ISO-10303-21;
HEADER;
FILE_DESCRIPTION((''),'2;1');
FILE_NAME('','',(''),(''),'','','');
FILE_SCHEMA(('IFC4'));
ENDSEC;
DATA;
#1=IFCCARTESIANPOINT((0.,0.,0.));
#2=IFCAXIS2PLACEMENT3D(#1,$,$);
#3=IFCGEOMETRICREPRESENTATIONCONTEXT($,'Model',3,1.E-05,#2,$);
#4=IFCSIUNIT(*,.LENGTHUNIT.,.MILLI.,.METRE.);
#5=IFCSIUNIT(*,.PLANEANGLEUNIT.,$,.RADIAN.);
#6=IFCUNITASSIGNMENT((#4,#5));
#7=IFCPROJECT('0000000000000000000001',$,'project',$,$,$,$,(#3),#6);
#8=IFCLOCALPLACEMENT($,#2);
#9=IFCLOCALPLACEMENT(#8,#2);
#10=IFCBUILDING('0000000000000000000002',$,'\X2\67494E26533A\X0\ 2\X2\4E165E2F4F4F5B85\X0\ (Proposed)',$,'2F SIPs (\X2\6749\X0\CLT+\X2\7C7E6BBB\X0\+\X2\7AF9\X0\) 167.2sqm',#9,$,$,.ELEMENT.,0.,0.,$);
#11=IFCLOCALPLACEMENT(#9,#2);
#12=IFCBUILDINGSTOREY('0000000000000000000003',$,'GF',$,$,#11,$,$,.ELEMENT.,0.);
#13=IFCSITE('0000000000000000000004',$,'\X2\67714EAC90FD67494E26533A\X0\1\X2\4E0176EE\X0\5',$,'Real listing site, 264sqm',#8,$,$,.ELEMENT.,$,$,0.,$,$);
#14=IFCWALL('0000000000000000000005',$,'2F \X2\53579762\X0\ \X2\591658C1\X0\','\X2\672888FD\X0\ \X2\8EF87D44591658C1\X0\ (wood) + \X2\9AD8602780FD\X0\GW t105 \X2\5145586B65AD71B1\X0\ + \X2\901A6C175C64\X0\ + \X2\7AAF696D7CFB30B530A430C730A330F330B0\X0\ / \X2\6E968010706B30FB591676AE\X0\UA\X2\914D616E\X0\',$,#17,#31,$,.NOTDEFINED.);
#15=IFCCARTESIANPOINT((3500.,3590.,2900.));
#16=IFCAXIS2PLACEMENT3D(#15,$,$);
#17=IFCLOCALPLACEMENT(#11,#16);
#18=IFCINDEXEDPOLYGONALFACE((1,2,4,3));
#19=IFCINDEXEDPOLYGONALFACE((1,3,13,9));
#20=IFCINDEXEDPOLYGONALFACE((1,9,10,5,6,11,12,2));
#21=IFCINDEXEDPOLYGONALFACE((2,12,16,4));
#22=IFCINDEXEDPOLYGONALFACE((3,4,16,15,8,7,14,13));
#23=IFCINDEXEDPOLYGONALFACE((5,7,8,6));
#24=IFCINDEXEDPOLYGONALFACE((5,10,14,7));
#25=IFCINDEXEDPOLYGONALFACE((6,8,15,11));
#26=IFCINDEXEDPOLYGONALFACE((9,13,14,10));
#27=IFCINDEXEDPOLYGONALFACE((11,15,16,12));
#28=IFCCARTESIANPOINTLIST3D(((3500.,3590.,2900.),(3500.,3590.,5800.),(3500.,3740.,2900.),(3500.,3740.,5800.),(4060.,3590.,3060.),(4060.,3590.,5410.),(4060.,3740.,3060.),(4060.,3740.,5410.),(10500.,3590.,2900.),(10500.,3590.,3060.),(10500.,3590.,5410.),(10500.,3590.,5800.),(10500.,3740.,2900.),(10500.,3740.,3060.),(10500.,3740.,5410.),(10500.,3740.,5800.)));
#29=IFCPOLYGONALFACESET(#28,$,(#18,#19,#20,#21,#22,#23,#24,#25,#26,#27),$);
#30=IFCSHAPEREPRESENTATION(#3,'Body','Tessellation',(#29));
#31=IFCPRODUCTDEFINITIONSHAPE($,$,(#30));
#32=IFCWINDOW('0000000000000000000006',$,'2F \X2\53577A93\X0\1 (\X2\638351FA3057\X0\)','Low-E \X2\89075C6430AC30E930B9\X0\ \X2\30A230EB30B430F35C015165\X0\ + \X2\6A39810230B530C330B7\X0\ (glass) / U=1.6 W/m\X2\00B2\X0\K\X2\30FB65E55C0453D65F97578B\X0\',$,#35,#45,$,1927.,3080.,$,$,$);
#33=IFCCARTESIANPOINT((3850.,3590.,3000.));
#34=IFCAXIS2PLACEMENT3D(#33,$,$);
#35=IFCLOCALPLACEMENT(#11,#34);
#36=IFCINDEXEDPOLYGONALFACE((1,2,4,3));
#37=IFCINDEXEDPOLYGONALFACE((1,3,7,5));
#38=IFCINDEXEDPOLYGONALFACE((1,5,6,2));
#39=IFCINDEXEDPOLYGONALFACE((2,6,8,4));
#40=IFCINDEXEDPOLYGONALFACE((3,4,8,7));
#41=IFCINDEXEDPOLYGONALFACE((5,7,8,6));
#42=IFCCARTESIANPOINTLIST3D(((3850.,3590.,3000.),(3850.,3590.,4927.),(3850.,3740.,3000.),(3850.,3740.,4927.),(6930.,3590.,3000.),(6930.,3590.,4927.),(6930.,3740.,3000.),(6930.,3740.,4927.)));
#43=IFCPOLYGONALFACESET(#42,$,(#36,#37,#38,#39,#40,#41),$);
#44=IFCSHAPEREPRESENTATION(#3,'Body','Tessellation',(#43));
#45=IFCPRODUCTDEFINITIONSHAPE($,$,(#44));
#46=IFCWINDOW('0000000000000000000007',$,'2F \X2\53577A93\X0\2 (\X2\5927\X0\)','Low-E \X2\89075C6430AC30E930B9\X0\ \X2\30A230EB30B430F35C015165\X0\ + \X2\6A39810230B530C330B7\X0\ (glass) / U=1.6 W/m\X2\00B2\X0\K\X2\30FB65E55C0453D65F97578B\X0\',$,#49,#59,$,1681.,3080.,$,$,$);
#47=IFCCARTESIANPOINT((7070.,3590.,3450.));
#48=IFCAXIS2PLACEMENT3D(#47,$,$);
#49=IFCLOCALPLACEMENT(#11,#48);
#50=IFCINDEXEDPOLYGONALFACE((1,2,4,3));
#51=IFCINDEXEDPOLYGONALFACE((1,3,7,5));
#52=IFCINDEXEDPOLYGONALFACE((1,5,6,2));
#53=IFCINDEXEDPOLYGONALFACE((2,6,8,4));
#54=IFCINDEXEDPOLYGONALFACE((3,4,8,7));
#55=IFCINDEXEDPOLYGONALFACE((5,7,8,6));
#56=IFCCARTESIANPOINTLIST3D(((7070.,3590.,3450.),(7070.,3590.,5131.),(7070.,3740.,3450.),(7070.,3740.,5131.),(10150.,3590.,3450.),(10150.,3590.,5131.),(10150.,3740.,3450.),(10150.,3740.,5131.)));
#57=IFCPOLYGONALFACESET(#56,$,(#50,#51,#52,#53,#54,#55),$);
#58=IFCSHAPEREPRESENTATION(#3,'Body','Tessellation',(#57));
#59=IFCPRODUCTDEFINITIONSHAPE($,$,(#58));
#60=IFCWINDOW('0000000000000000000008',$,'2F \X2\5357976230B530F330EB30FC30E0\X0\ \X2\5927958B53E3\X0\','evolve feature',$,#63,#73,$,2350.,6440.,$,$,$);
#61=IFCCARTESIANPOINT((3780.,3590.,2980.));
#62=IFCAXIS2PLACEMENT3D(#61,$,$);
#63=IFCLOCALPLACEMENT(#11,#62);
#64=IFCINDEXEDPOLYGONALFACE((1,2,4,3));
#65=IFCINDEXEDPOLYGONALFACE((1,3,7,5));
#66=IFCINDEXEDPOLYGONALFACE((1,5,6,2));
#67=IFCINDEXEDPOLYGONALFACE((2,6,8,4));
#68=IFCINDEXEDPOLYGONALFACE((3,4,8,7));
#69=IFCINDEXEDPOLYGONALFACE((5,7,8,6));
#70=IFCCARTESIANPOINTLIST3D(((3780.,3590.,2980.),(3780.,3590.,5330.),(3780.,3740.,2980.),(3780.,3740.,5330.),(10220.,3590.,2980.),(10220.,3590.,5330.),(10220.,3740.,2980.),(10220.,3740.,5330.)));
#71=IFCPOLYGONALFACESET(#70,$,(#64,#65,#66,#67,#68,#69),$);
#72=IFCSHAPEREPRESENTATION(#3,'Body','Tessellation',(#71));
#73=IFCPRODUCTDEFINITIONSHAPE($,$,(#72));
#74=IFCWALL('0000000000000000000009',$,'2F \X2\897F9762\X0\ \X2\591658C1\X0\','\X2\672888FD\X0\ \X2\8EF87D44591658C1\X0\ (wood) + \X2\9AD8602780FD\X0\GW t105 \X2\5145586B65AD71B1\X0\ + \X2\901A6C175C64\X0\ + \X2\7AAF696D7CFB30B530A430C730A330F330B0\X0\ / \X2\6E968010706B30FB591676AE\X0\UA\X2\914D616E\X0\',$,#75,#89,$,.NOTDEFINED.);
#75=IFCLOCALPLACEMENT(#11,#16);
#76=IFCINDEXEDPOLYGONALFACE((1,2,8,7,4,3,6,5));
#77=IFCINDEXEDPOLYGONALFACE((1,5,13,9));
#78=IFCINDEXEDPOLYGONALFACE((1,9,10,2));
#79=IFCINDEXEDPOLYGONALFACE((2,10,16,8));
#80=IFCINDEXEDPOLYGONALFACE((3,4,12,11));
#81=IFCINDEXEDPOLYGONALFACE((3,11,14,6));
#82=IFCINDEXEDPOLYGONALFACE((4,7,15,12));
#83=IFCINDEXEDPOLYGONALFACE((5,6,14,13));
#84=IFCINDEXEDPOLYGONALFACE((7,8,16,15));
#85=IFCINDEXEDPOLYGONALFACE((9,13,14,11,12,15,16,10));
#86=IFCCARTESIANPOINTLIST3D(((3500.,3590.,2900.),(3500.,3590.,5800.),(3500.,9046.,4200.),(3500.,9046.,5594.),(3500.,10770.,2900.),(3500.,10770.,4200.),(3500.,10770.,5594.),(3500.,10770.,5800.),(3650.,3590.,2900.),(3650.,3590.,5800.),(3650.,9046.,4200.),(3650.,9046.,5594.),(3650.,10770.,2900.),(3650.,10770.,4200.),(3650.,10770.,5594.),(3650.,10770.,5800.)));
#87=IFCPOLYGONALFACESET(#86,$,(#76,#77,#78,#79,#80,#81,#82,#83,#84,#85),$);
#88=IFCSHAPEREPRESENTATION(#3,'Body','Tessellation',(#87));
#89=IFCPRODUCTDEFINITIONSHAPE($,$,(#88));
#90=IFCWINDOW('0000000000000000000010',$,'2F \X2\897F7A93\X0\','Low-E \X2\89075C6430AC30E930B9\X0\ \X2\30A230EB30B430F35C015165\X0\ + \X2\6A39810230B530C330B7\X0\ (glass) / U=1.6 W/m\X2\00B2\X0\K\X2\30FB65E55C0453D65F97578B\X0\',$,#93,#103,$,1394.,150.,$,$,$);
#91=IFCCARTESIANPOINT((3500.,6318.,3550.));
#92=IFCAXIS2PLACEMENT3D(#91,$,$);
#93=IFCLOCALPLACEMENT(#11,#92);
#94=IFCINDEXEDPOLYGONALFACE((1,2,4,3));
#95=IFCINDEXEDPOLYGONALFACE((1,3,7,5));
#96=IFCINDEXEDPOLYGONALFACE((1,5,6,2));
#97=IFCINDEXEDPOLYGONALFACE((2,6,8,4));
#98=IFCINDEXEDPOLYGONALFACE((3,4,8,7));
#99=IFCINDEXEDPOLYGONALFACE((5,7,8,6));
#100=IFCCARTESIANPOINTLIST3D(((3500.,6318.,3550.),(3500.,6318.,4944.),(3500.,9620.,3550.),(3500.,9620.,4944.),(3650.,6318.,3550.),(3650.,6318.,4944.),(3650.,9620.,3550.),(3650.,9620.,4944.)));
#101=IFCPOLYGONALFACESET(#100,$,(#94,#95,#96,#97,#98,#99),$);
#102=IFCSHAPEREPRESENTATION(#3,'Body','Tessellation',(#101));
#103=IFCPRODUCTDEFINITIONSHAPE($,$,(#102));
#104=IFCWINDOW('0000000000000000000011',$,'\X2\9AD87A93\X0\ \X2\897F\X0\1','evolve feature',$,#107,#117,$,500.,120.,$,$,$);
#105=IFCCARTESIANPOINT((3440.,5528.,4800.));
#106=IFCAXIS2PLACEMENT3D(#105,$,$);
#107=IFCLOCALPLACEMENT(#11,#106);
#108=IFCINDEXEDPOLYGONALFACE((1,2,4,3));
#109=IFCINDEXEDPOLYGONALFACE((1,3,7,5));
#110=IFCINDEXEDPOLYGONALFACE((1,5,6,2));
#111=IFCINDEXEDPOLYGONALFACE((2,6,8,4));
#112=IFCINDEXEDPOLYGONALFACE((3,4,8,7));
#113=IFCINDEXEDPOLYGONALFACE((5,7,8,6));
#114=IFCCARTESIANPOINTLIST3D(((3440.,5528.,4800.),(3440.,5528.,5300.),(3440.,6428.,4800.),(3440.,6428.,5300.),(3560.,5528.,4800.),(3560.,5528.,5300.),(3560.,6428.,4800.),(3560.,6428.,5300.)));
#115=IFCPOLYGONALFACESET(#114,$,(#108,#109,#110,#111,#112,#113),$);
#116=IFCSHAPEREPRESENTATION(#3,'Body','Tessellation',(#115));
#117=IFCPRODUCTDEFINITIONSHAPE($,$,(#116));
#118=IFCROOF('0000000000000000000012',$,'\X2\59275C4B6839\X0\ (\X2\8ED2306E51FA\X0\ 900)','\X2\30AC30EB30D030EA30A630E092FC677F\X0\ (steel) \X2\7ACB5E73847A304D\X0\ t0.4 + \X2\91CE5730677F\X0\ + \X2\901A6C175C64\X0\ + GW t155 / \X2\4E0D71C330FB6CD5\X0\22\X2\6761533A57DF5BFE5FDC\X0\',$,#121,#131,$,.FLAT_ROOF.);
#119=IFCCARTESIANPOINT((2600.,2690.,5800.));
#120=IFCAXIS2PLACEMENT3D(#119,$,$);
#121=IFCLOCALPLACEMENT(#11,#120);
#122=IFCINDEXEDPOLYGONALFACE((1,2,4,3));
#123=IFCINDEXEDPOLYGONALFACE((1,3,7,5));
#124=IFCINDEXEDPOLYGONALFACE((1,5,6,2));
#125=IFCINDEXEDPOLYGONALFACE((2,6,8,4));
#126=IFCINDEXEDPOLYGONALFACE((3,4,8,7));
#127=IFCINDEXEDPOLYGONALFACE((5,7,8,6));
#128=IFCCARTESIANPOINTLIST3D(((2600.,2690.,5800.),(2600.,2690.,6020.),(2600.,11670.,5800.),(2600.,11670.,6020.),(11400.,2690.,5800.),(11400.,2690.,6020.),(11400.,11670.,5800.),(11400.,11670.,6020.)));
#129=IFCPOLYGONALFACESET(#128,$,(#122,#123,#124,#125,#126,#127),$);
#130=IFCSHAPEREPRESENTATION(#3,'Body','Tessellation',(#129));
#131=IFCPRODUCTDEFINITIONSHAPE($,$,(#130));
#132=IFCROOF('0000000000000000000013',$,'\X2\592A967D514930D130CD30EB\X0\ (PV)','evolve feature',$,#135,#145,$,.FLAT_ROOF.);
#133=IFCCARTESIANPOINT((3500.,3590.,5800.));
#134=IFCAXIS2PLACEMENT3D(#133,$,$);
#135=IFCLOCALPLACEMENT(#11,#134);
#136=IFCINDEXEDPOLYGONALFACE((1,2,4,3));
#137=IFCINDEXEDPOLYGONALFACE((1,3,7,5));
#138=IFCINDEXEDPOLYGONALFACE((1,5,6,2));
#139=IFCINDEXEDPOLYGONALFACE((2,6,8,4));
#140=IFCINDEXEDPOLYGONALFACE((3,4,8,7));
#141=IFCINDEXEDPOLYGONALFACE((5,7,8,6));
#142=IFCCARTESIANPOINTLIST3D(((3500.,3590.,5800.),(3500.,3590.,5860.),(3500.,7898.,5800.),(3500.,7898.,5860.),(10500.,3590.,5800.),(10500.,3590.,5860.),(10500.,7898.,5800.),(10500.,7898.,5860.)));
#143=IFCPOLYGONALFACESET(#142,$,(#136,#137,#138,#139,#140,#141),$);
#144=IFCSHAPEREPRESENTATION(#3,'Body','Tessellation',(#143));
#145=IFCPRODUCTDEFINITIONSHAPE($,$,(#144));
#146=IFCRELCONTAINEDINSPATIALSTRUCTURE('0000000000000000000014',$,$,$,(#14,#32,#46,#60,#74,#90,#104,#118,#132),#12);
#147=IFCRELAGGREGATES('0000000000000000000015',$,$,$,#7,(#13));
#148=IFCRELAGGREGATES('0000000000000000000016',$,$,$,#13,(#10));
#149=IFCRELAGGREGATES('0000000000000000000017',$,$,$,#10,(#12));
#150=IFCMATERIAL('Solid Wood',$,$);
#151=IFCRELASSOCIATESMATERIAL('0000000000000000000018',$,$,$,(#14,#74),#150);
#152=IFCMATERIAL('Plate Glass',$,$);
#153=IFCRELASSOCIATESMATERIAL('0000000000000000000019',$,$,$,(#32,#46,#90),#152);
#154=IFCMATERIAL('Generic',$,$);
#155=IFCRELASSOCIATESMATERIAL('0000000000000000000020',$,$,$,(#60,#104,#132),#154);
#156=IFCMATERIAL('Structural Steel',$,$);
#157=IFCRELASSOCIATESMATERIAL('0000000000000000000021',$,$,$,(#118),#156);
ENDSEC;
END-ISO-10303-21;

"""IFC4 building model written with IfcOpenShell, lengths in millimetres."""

from ifc_helpers import new_model, si_unit, frame, frame_2d, origin, place, context, project, spatial, rectangle, extrude, material, element, fill, save


model = new_model("IFC4")

# Units and contexts
model_context = context("Model", 3, precision=1e-05, world=origin())
ifc_project = project(units=[si_unit("LENGTHUNIT", "METRE", prefix="MILLI"), si_unit("PLANEANGLEUNIT", "RADIAN")], contexts=[model_context])

# Site, building, storey
site_placement = place(None, origin())
site = spatial("IfcSite", under=ifc_project, at=site_placement, Name="東京都杉並区1丁目5", ObjectType="Real listing site, 264sqm", CompositionType="ELEMENT", RefElevation=0.0)
building_placement = place(site_placement, origin())
building = spatial("IfcBuilding", under=site, at=building_placement, Name="杉並区 2世帯住宅 (Proposed)", ObjectType="2F SIPs (杉CLT+籾殻+竹) 167.2sqm", CompositionType="ELEMENT", ElevationOfRefHeight=0.0, ElevationOfTerrain=0.0)
storey_placement = place(building_placement, origin())
storey = spatial("IfcBuildingStorey", under=building, at=storey_placement, Name="GF", CompositionType="ELEMENT", Elevation=0.0)

# Shared definitions
ifc_material_1 = material(Name="Solid Wood")
ifc_material_2 = material(Name="Generic")

# Shared definitions
ifc_material_3 = material(Name="Plate Glass")

# Walls, openings, windows
wall_1_placement = place(storey_placement, frame((3500.0, 3590.0, 2900.0)))
wall_1 = element("IfcWall", 1, at=wall_1_placement, inside=storey, material=ifc_material_1, Name="2F 南面 外壁", Description="木製 軸組外壁 (wood) + 高性能GW t105 充填断熱 + 通気層 + 窯業系サイディング / 準耐火・外皮UA配慮", PredefinedType="NOTDEFINED", context=model_context, shape_type="SweptSolid", body=[
    extrude(rectangle(XDim=7000.0, YDim=150.0, at=frame_2d((3500.0, 75.0))), frame((3500.0, 3590.0, 2900.0)), (0.0, 0.0, 1.0), 2900.0),
])
opening_1_placement = place(storey_placement, frame((3850.0, 3590.0, 3000.0)))
opening_1 = element("IfcOpeningElement", 2, at=opening_1_placement, cuts=wall_1, PredefinedType="NOTDEFINED", context=model_context, shape_type="SweptSolid", body=[
    extrude(rectangle(XDim=3080.0, YDim=150.0, at=frame_2d((1540.0, 75.0))), frame((3850.0, 3590.0, 3000.0)), (0.0, 0.0, 1.0), 1927.0),
])
opening_2_placement = place(storey_placement, frame((7070.0, 3590.0, 3450.0)))
opening_2 = element("IfcOpeningElement", 3, at=opening_2_placement, cuts=wall_1, PredefinedType="NOTDEFINED", context=model_context, shape_type="SweptSolid", body=[
    extrude(rectangle(XDim=3080.0, YDim=150.0, at=frame_2d((1540.0, 75.0))), frame((7070.0, 3590.0, 3450.0)), (0.0, 0.0, 1.0), 1681.0),
])
opening_3_placement = place(storey_placement, frame((3780.0, 3590.0, 2980.0)))
opening_3 = element("IfcOpeningElement", 4, at=opening_3_placement, cuts=wall_1, PredefinedType="NOTDEFINED", context=model_context, shape_type="SweptSolid", body=[
    extrude(rectangle(XDim=6440.0, YDim=150.0, at=frame_2d((3220.0, 75.0))), frame((3780.0, 3590.0, 2980.0)), (0.0, 0.0, 1.0), 2350.0),
])
window_1_placement = place(storey_placement, frame((3850.0, 3590.0, 3000.0)))
window_1 = element("IfcWindow", 5, at=window_1_placement, inside=storey, material=ifc_material_3, Name="2F 南窓1 (掃出し)", Description="Low-E 複層ガラス アルゴン封入 + 樹脂サッシ (glass) / U=1.6 W/m²K・日射取得型", OverallHeight=1927.0, OverallWidth=3080.0, context=model_context, shape_type="SweptSolid", body=[
    extrude(rectangle(XDim=3080.0, YDim=150.0, at=frame_2d((1540.0, 75.0))), frame((3850.0, 3590.0, 3000.0)), (0.0, 0.0, 1.0), 1927.0),
])
fill(opening_1, window_1)
window_2_placement = place(storey_placement, frame((7070.0, 3590.0, 3450.0)))
window_2 = element("IfcWindow", 6, at=window_2_placement, inside=storey, material=ifc_material_3, Name="2F 南窓2 (大)", Description="Low-E 複層ガラス アルゴン封入 + 樹脂サッシ (glass) / U=1.6 W/m²K・日射取得型", OverallHeight=1681.0, OverallWidth=3080.0, context=model_context, shape_type="SweptSolid", body=[
    extrude(rectangle(XDim=3080.0, YDim=150.0, at=frame_2d((1540.0, 75.0))), frame((7070.0, 3590.0, 3450.0)), (0.0, 0.0, 1.0), 1681.0),
])
fill(opening_2, window_2)
window_3_placement = place(storey_placement, frame((3780.0, 3590.0, 2980.0)))
window_3 = element("IfcWindow", 7, at=window_3_placement, inside=storey, material=ifc_material_2, Name="2F 南面サンルーム 大開口", Description="evolve feature", OverallHeight=2350.0, OverallWidth=6440.0, context=model_context, shape_type="SweptSolid", body=[
    extrude(rectangle(XDim=6440.0, YDim=150.0, at=frame_2d((3220.0, 75.0))), frame((3780.0, 3590.0, 2980.0)), (0.0, 0.0, 1.0), 2350.0),
])
fill(opening_3, window_3)
wall_2_placement = place(storey_placement, frame((3500.0, 3590.0, 2900.0)))
wall_2 = element("IfcWall", 8, at=wall_2_placement, inside=storey, material=ifc_material_1, Name="2F 西面 外壁", Description="木製 軸組外壁 (wood) + 高性能GW t105 充填断熱 + 通気層 + 窯業系サイディング / 準耐火・外皮UA配慮", PredefinedType="NOTDEFINED", context=model_context, shape_type="SweptSolid", body=[
    extrude(rectangle(XDim=150.0, YDim=7180.0, at=frame_2d((75.0, 3590.0))), frame((3500.0, 3590.0, 2900.0)), (0.0, 0.0, 1.0), 2900.0),
])
opening_4_placement = place(storey_placement, frame((3500.0, 6318.0, 3550.0)))
opening_4 = element("IfcOpeningElement", 9, at=opening_4_placement, cuts=wall_2, PredefinedType="NOTDEFINED", context=model_context, shape_type="SweptSolid", body=[
    extrude(rectangle(XDim=150.0, YDim=3302.0, at=frame_2d((75.0, 1651.0))), frame((3500.0, 6318.0, 3550.0)), (0.0, 0.0, 1.0), 1394.0),
])
opening_5_placement = place(storey_placement, frame((3440.0, 5528.0, 4800.0)))
opening_5 = element("IfcOpeningElement", 10, at=opening_5_placement, cuts=wall_2, PredefinedType="NOTDEFINED", context=model_context, shape_type="SweptSolid", body=[
    extrude(rectangle(XDim=120.0, YDim=900.0, at=frame_2d((60.0, 450.0))), frame((3440.0, 5528.0, 4800.0)), (0.0, 0.0, 1.0), 500.0),
])
window_4_placement = place(storey_placement, frame((3500.0, 6318.0, 3550.0)))
window_4 = element("IfcWindow", 11, at=window_4_placement, inside=storey, material=ifc_material_3, Name="2F 西窓", Description="Low-E 複層ガラス アルゴン封入 + 樹脂サッシ (glass) / U=1.6 W/m²K・日射取得型", OverallHeight=1394.0, OverallWidth=150.0, context=model_context, shape_type="SweptSolid", body=[
    extrude(rectangle(XDim=150.0, YDim=3302.0, at=frame_2d((75.0, 1651.0))), frame((3500.0, 6318.0, 3550.0)), (0.0, 0.0, 1.0), 1394.0),
])
fill(opening_4, window_4)
window_5_placement = place(storey_placement, frame((3440.0, 5528.0, 4800.0)))
window_5 = element("IfcWindow", 12, at=window_5_placement, inside=storey, material=ifc_material_2, Name="高窓 西1", Description="evolve feature", OverallHeight=500.0, OverallWidth=120.0, context=model_context, shape_type="SweptSolid", body=[
    extrude(rectangle(XDim=120.0, YDim=900.0, at=frame_2d((60.0, 450.0))), frame((3440.0, 5528.0, 4800.0)), (0.0, 0.0, 1.0), 500.0),
])
fill(opening_5, window_5)

# Roofs
ifc_material_4 = material(Name="Structural Steel")
roof_1_placement = place(storey_placement, frame((2600.0, 2690.0, 5800.0)))
element("IfcRoof", 13, at=roof_1_placement, inside=storey, material=ifc_material_4, Name="大屋根 (軒の出 900)", Description="ガルバリウム鋼板 (steel) 立平葺き t0.4 + 野地板 + 通気層 + GW t155 / 不燃・法22条区域対応", PredefinedType="FLAT_ROOF", context=model_context, shape_type="SweptSolid", body=[
    extrude(rectangle(XDim=8800.0, YDim=8980.0, at=frame_2d((4400.0, 4490.0))), frame((2600.0, 2690.0, 5800.0)), (0.0, 0.0, 1.0), 220.0),
])
roof_2_placement = place(storey_placement, frame((3500.0, 3590.0, 5800.0)))
element("IfcRoof", 14, at=roof_2_placement, inside=storey, material=ifc_material_2, Name="太陽光パネル (PV)", Description="evolve feature", PredefinedType="FLAT_ROOF", context=model_context, shape_type="SweptSolid", body=[
    extrude(rectangle(XDim=7000.0, YDim=4308.0, at=frame_2d((3500.0, 2154.0))), frame((3500.0, 3590.0, 5800.0)), (0.0, 0.0, 1.0), 60.0),
])

save(model, "model.ifc")
